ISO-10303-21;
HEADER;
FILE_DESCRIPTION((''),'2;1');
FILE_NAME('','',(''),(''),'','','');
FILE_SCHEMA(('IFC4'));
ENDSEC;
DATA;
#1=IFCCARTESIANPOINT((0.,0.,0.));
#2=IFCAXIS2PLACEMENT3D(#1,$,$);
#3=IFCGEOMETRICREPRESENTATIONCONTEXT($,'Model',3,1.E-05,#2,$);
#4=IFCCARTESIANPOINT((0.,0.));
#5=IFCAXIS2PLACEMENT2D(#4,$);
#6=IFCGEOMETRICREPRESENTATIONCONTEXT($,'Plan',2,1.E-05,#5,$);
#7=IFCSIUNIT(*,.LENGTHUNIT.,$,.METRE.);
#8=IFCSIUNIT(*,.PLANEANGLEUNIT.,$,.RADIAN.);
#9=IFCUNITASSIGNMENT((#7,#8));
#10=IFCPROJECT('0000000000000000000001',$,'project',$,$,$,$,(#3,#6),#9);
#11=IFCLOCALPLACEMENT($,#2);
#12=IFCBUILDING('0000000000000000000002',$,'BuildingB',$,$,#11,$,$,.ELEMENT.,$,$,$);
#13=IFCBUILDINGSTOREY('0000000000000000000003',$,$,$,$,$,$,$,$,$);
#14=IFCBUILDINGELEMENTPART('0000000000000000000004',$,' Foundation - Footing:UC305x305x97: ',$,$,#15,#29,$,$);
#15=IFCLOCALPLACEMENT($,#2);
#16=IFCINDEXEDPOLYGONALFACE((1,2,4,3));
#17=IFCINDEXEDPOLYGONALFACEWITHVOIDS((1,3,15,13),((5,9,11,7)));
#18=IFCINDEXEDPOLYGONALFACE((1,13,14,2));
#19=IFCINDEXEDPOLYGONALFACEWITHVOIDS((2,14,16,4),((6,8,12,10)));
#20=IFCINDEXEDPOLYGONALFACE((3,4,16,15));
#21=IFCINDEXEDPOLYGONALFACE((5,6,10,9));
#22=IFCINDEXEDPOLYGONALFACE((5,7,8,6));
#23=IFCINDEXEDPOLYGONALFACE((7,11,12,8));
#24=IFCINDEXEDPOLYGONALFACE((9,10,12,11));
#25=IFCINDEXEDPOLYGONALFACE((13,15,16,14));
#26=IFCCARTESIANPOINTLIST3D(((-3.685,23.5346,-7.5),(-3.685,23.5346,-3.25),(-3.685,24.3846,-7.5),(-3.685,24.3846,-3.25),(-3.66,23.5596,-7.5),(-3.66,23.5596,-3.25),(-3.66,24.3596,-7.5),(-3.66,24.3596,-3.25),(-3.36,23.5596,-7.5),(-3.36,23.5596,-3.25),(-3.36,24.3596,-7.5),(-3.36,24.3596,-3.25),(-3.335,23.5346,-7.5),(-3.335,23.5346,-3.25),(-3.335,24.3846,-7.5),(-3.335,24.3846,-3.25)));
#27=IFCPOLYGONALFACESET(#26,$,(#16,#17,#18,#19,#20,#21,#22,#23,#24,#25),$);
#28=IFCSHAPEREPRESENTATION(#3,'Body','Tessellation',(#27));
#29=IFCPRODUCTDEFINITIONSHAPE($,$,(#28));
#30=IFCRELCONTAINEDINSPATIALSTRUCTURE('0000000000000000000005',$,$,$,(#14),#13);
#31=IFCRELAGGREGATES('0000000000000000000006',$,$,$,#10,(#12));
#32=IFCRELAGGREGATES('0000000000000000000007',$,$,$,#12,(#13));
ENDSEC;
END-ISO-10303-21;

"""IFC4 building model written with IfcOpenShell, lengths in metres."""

from ifc_helpers import new_model, si_unit, origin, origin_2d, place, context, project, spatial, polyline, outline, extrude, element, save


model = new_model("IFC4")

# Units and contexts
model_context = context("Model", 3, precision=1e-05, world=origin())
plan_context = context("Plan", 2, precision=1e-05, world=origin_2d())
ifc_project = project(units=[si_unit("LENGTHUNIT", "METRE"), si_unit("PLANEANGLEUNIT", "RADIAN")], contexts=[model_context, plan_context])

# Building, storey
building_placement = place(None, origin())
building = spatial("IfcBuilding", under=ifc_project, at=building_placement, Name="BuildingB", CompositionType="ELEMENT")
storey = spatial("IfcBuildingStorey", under=building)

# Building element part, opening
building_element_part_1 = element("IfcBuildingElementPart", 1, inside=storey, Name=" Foundation - Footing:UC305x305x97: ", context=model_context, shape_type="SweptSolid", body=[
    extrude(outline(polyline([(-3.685, 23.5346, -7.5), (-3.335, 23.5346, -7.5), (-3.335, 24.3846, -7.5), (-3.685, 24.3846, -7.5), (-3.685, 23.5346, -7.5)])), None, (0.0, 0.0, 1.0), 4.25),
])
element("IfcOpeningElement", 2, inside=storey, cuts=building_element_part_1, context=model_context, shape_type="SweptSolid", body=[
    extrude(outline(polyline([(-3.66, 23.5596, -7.5), (-3.36, 23.5596, -7.5), (-3.36, 24.3596, -7.5), (-3.66, 24.3596, -7.5), (-3.66, 23.5596, -7.5)])), None, (0.0, 0.0, 1.0), 4.25),
])

save(model, "model.ifc")
